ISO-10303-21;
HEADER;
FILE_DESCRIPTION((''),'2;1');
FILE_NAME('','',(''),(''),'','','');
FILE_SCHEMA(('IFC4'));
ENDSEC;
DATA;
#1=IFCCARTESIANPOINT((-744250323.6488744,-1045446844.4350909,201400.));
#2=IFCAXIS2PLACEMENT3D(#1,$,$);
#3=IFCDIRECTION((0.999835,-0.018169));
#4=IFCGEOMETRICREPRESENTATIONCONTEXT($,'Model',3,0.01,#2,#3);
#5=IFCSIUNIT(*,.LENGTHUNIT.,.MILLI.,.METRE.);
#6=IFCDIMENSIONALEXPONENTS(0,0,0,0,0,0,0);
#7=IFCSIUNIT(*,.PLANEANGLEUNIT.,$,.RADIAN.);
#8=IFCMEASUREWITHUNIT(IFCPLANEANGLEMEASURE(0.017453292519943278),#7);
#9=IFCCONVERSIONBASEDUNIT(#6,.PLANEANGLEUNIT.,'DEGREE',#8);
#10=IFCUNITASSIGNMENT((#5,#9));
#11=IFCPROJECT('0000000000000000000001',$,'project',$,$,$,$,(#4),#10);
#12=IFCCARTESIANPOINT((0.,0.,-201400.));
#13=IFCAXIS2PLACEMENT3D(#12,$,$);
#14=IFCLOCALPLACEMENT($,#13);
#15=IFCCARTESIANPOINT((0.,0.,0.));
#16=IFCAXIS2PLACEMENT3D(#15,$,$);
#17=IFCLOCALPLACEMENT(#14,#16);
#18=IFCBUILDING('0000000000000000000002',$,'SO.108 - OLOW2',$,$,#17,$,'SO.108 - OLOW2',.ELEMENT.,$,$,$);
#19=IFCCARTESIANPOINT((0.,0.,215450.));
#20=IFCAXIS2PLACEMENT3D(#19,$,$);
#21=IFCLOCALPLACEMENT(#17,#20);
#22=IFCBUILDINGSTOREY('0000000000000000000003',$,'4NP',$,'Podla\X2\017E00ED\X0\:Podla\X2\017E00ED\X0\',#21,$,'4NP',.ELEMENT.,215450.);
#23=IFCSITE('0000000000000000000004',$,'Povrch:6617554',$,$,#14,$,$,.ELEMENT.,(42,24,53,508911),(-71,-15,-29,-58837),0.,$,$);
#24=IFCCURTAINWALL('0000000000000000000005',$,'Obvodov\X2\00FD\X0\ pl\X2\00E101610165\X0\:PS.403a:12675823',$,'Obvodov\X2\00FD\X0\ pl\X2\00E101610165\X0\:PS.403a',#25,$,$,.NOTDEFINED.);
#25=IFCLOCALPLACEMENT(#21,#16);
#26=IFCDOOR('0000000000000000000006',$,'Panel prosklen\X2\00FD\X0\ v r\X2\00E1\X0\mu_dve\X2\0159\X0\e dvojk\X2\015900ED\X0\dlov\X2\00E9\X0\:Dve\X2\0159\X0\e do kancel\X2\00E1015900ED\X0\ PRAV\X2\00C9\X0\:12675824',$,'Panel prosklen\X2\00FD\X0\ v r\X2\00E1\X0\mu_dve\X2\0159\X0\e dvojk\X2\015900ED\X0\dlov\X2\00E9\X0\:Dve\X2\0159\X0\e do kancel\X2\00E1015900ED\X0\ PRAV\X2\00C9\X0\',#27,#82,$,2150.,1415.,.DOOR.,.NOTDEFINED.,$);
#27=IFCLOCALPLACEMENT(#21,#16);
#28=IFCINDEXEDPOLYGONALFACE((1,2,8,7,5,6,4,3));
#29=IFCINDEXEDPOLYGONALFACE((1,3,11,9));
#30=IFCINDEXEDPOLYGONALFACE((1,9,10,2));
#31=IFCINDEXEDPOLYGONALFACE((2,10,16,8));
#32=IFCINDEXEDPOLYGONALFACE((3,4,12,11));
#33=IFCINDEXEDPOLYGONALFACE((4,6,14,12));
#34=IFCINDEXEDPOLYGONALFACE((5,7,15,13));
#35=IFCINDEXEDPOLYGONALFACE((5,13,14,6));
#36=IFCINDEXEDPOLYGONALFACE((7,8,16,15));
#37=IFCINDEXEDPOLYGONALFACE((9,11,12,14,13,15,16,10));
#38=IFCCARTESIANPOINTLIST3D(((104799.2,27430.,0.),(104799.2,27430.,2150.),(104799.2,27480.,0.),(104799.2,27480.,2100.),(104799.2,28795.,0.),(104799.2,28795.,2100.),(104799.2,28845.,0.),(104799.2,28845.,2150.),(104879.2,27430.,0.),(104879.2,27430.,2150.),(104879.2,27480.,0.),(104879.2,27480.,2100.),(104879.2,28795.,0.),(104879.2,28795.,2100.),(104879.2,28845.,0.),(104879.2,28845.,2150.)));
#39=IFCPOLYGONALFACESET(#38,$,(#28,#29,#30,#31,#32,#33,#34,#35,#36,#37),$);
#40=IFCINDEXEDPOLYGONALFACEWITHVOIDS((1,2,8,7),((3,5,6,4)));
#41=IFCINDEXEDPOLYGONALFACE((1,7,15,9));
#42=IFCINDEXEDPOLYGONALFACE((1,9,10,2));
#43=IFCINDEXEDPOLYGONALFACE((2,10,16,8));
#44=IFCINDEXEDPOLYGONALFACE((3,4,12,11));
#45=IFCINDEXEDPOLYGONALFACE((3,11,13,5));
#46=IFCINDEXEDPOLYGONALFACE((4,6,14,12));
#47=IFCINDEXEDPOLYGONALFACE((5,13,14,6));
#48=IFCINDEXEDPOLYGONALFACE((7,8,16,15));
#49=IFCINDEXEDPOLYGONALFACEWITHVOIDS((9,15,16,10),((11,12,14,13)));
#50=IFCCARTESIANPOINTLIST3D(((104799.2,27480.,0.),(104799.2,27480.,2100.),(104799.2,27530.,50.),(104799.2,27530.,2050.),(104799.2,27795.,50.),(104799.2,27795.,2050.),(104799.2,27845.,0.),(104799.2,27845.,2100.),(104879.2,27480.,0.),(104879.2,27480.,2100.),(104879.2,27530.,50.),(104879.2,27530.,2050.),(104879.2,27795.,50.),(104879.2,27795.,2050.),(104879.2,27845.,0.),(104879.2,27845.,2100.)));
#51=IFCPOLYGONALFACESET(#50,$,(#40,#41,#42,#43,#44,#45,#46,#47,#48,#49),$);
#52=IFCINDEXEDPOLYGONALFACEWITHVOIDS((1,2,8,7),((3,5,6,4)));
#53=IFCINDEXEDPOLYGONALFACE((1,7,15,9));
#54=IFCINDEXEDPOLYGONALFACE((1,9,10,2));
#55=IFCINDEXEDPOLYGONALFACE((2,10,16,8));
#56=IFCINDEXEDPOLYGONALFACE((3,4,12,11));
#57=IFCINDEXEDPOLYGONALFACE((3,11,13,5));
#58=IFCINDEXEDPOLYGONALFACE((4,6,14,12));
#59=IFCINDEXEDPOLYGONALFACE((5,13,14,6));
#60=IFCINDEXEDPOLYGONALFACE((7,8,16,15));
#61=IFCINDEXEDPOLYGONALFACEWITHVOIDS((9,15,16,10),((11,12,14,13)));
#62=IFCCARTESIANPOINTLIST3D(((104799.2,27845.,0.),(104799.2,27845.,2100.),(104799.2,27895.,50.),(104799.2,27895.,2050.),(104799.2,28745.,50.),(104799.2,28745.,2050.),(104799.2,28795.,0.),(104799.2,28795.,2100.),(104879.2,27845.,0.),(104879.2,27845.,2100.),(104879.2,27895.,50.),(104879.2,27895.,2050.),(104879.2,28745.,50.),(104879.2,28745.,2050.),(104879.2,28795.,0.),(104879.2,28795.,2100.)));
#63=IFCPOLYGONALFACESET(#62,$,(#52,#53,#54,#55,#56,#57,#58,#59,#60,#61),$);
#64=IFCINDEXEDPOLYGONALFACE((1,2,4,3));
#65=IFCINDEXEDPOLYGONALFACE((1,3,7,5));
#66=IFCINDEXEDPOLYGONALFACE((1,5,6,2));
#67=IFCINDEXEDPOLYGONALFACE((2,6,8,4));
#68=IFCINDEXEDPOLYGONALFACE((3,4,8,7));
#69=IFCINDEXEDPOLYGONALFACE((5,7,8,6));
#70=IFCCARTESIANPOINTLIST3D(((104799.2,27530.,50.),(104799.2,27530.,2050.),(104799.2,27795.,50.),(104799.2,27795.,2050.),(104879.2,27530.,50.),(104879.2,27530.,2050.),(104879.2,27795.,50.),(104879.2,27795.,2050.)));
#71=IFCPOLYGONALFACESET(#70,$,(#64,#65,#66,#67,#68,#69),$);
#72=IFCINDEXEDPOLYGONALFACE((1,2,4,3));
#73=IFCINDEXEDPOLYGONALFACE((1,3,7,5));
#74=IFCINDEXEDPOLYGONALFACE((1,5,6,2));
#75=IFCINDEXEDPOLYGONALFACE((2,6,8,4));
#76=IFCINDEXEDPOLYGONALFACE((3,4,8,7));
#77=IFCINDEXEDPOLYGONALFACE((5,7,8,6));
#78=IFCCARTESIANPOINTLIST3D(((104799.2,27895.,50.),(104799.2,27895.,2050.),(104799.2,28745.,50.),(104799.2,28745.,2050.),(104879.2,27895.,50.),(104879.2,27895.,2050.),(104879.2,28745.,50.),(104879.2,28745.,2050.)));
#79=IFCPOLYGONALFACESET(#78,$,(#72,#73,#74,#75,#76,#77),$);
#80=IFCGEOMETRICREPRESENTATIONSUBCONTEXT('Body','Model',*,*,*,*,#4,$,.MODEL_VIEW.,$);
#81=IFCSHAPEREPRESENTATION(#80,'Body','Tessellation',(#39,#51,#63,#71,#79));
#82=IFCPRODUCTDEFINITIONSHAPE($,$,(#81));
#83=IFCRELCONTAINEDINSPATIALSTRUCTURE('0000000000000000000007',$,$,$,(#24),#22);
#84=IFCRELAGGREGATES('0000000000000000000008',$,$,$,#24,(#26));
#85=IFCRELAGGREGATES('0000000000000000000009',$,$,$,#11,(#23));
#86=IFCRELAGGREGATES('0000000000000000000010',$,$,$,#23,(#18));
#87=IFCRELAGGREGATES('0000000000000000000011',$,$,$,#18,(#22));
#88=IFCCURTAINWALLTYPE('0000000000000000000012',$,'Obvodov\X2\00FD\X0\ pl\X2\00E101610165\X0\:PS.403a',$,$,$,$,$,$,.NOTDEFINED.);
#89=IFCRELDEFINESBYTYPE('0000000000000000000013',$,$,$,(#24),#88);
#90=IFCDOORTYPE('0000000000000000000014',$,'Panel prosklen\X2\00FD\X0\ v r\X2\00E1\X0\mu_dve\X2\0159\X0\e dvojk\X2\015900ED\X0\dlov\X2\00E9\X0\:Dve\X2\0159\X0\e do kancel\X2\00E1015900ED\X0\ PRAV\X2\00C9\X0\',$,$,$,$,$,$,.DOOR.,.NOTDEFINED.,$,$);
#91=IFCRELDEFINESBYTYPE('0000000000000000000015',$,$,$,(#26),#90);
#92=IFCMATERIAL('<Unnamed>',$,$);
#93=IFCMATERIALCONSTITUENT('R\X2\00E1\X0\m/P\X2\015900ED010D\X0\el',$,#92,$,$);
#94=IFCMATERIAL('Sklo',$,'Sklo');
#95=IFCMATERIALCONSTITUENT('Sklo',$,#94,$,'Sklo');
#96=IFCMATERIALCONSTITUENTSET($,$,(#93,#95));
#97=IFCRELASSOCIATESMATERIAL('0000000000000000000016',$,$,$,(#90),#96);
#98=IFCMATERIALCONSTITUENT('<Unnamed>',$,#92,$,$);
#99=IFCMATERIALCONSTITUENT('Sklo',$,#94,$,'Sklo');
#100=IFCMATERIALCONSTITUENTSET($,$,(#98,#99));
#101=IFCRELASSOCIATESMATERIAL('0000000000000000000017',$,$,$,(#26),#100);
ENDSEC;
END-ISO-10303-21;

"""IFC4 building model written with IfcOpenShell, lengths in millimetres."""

from ifc_helpers import new_model, entity, si_unit, converted_unit, direction, frame, origin, place, context, subcontext, project, spatial, indexed_curve, outline, extrude, source, transform, mapped, material, constituent, constituent_set, type_object, type_shapes, element, aggregate, save


model = new_model("IFC4")

# Units and contexts
model_context = context("Model", 3, precision=0.01, world=frame((-744250323.6488744, -1045446844.4350909, 201400.0)), true_north=direction((0.999835, -0.018169)))
body_context = subcontext(model_context, "Body", "Model", "MODEL_VIEW")
ifc_project = project(units=[si_unit("LENGTHUNIT", "METRE", prefix="MILLI"), converted_unit("PLANEANGLEUNIT", "DEGREE", entity("IfcPlaneAngleMeasure", 0.017453292519943278), si_unit("PLANEANGLEUNIT", "RADIAN"), dimensions=[0, 0, 0, 0, 0, 0, 0])], contexts=[model_context])

# Site, building, storey
site_placement = place(None, frame((0.0, 0.0, -201400.0)))
site = spatial("IfcSite", under=ifc_project, at=site_placement, Name="Povrch:6617554", CompositionType="ELEMENT", RefLatitude=(42, 24, 53, 508911), RefLongitude=(-71, -15, -29, -58837), RefElevation=0.0)
building_placement = place(site_placement, origin())
building = spatial("IfcBuilding", under=site, at=building_placement, Name="SO.108 - OLOW2", LongName="SO.108 - OLOW2", CompositionType="ELEMENT")
storey_placement = place(building_placement, frame((0.0, 0.0, 215450.0)))
storey = spatial("IfcBuildingStorey", under=building, at=storey_placement, Name="4NP", ObjectType="Podlaží:Podlaží", LongName="4NP", CompositionType="ELEMENT", Elevation=215450.0)

# Shared definitions
ifc_material_1 = material(Name="<Unnamed>")

# Curtain wall
curtain_wall_type_1 = type_object("IfcCurtainWallType", Name="Obvodový plášť:PS.403a", PredefinedType="NOTDEFINED")
curtain_wall_1_placement = place(storey_placement, frame((0.0, 0.0, -215450.0)))
curtain_wall_1 = element("IfcCurtainWall", 1, at=curtain_wall_1_placement, inside=storey, type_object=curtain_wall_type_1, Name="Obvodový plášť:PS.403a:12675823", ObjectType="Obvodový plášť:PS.403a", PredefinedType="NOTDEFINED")

# Shared definitions
ifc_material_2 = material(Name="Sklo", Category="Sklo")

# Door
ifc_constituent_1 = constituent(ifc_material_1, Name="<Unnamed>")
ifc_constituent_2 = constituent(ifc_material_2, Name="Sklo", Category="Sklo")
ifc_constituent_set_1 = constituent_set(constituents=[ifc_constituent_1, ifc_constituent_2])
ifc_constituent_3 = constituent(ifc_material_1, Name="Rám/Příčel")
ifc_constituent_4 = constituent(ifc_material_2, Name="Sklo", Category="Sklo")
ifc_constituent_set_2 = constituent_set(constituents=[ifc_constituent_3, ifc_constituent_4])
door_type = type_object("IfcDoorType", Name="Panel prosklený v rámu_dveře dvojkřídlové:Dveře do kanceláří PRAVÉ", OperationType="NOTDEFINED", PredefinedType="DOOR", material=ifc_constituent_set_2)
shared_shape_1 = source(origin(), body_context, "Body", "SweptSolid", [
    extrude(outline(indexed_curve([(-707.5, -1087.5), (707.5, -1087.5), (707.5, 1062.5), (657.5, 1062.5), (657.5, -1037.5), (-657.5, -1037.5), (-657.5, 1062.5), (-707.5, 1062.5), (-707.5, -1087.5)], self_intersect=False)), frame((0.0, -40.0, 1062.5), z_axis=(0.0, 1.0, 0.0), x_axis=(1.0, 0.0, 0.0)), (0.0, 0.0, 1.0), 80.0),
    extrude(outline(indexed_curve([(-1050.0, -182.5), (1050.0, -182.5), (1050.0, 182.5), (-1050.0, 182.5), (-1050.0, -182.5)], self_intersect=False), holes=[indexed_curve([(-1000.0, -132.5), (-1000.0, 132.5), (1000.0, 132.5), (1000.0, -132.5), (-1000.0, -132.5)], self_intersect=False)]), frame((475.0, -40.0, 1050.0), z_axis=(0.0, 1.0, 0.0), x_axis=(0.0, 0.0, -1.0)), (0.0, 0.0, 1.0), 80.0),
    extrude(outline(indexed_curve([(-1050.0, -475.0), (1050.0, -475.0), (1050.0, 475.0), (-1050.0, 475.0), (-1050.0, -475.0)], self_intersect=False), holes=[indexed_curve([(-1000.0, -425.0), (-1000.0, 425.0), (1000.0, 425.0), (1000.0, -425.0), (-1000.0, -425.0)], self_intersect=False)]), frame((-182.5, -40.0, 1050.0), z_axis=(0.0, 1.0, 0.0), x_axis=(0.0, 0.0, -1.0)), (0.0, 0.0, 1.0), 80.0),
    extrude(outline(indexed_curve([(-40.0, -132.5), (40.0, -132.5), (40.0, 132.5), (-40.0, 132.5), (-40.0, -132.5)], self_intersect=False)), frame((475.0, 0.0, 50.0), z_axis=(0.0, 0.0, 1.0), x_axis=(0.0, 1.0, 0.0)), (0.0, 0.0, 1.0), 2000.0),
    extrude(outline(indexed_curve([(-40.0, -425.0), (40.0, -425.0), (40.0, 425.0), (-40.0, 425.0), (-40.0, -425.0)], self_intersect=False)), frame((-182.5, 0.0, 50.0), z_axis=(0.0, 0.0, 1.0), x_axis=(0.0, 1.0, 0.0)), (0.0, 0.0, 1.0), 2000.0),
])
type_shapes(door_type, [shared_shape_1])
door_placement = place(curtain_wall_1_placement, frame((104839.2, 28137.5, 215450.0), z_axis=(0.0, 0.0, 1.0), x_axis=(0.0, -1.0, 0.0)))
door = element("IfcDoor", 2, at=door_placement, type_object=door_type, material=ifc_constituent_set_1, Name="Panel prosklený v rámu_dveře dvojkřídlové:Dveře do kanceláří PRAVÉ:12675824", ObjectType="Panel prosklený v rámu_dveře dvojkřídlové:Dveře do kanceláří PRAVÉ", OperationType="NOTDEFINED", OverallHeight=2150.0, OverallWidth=1415.0, PredefinedType="DOOR", context=body_context, shape_type="MappedRepresentation", body=[
    mapped(shared_shape_1, transform((0.0, 0.0, 0.0), scale=1.0)),
])
aggregate(curtain_wall_1, [door])

save(model, "model.ifc")
